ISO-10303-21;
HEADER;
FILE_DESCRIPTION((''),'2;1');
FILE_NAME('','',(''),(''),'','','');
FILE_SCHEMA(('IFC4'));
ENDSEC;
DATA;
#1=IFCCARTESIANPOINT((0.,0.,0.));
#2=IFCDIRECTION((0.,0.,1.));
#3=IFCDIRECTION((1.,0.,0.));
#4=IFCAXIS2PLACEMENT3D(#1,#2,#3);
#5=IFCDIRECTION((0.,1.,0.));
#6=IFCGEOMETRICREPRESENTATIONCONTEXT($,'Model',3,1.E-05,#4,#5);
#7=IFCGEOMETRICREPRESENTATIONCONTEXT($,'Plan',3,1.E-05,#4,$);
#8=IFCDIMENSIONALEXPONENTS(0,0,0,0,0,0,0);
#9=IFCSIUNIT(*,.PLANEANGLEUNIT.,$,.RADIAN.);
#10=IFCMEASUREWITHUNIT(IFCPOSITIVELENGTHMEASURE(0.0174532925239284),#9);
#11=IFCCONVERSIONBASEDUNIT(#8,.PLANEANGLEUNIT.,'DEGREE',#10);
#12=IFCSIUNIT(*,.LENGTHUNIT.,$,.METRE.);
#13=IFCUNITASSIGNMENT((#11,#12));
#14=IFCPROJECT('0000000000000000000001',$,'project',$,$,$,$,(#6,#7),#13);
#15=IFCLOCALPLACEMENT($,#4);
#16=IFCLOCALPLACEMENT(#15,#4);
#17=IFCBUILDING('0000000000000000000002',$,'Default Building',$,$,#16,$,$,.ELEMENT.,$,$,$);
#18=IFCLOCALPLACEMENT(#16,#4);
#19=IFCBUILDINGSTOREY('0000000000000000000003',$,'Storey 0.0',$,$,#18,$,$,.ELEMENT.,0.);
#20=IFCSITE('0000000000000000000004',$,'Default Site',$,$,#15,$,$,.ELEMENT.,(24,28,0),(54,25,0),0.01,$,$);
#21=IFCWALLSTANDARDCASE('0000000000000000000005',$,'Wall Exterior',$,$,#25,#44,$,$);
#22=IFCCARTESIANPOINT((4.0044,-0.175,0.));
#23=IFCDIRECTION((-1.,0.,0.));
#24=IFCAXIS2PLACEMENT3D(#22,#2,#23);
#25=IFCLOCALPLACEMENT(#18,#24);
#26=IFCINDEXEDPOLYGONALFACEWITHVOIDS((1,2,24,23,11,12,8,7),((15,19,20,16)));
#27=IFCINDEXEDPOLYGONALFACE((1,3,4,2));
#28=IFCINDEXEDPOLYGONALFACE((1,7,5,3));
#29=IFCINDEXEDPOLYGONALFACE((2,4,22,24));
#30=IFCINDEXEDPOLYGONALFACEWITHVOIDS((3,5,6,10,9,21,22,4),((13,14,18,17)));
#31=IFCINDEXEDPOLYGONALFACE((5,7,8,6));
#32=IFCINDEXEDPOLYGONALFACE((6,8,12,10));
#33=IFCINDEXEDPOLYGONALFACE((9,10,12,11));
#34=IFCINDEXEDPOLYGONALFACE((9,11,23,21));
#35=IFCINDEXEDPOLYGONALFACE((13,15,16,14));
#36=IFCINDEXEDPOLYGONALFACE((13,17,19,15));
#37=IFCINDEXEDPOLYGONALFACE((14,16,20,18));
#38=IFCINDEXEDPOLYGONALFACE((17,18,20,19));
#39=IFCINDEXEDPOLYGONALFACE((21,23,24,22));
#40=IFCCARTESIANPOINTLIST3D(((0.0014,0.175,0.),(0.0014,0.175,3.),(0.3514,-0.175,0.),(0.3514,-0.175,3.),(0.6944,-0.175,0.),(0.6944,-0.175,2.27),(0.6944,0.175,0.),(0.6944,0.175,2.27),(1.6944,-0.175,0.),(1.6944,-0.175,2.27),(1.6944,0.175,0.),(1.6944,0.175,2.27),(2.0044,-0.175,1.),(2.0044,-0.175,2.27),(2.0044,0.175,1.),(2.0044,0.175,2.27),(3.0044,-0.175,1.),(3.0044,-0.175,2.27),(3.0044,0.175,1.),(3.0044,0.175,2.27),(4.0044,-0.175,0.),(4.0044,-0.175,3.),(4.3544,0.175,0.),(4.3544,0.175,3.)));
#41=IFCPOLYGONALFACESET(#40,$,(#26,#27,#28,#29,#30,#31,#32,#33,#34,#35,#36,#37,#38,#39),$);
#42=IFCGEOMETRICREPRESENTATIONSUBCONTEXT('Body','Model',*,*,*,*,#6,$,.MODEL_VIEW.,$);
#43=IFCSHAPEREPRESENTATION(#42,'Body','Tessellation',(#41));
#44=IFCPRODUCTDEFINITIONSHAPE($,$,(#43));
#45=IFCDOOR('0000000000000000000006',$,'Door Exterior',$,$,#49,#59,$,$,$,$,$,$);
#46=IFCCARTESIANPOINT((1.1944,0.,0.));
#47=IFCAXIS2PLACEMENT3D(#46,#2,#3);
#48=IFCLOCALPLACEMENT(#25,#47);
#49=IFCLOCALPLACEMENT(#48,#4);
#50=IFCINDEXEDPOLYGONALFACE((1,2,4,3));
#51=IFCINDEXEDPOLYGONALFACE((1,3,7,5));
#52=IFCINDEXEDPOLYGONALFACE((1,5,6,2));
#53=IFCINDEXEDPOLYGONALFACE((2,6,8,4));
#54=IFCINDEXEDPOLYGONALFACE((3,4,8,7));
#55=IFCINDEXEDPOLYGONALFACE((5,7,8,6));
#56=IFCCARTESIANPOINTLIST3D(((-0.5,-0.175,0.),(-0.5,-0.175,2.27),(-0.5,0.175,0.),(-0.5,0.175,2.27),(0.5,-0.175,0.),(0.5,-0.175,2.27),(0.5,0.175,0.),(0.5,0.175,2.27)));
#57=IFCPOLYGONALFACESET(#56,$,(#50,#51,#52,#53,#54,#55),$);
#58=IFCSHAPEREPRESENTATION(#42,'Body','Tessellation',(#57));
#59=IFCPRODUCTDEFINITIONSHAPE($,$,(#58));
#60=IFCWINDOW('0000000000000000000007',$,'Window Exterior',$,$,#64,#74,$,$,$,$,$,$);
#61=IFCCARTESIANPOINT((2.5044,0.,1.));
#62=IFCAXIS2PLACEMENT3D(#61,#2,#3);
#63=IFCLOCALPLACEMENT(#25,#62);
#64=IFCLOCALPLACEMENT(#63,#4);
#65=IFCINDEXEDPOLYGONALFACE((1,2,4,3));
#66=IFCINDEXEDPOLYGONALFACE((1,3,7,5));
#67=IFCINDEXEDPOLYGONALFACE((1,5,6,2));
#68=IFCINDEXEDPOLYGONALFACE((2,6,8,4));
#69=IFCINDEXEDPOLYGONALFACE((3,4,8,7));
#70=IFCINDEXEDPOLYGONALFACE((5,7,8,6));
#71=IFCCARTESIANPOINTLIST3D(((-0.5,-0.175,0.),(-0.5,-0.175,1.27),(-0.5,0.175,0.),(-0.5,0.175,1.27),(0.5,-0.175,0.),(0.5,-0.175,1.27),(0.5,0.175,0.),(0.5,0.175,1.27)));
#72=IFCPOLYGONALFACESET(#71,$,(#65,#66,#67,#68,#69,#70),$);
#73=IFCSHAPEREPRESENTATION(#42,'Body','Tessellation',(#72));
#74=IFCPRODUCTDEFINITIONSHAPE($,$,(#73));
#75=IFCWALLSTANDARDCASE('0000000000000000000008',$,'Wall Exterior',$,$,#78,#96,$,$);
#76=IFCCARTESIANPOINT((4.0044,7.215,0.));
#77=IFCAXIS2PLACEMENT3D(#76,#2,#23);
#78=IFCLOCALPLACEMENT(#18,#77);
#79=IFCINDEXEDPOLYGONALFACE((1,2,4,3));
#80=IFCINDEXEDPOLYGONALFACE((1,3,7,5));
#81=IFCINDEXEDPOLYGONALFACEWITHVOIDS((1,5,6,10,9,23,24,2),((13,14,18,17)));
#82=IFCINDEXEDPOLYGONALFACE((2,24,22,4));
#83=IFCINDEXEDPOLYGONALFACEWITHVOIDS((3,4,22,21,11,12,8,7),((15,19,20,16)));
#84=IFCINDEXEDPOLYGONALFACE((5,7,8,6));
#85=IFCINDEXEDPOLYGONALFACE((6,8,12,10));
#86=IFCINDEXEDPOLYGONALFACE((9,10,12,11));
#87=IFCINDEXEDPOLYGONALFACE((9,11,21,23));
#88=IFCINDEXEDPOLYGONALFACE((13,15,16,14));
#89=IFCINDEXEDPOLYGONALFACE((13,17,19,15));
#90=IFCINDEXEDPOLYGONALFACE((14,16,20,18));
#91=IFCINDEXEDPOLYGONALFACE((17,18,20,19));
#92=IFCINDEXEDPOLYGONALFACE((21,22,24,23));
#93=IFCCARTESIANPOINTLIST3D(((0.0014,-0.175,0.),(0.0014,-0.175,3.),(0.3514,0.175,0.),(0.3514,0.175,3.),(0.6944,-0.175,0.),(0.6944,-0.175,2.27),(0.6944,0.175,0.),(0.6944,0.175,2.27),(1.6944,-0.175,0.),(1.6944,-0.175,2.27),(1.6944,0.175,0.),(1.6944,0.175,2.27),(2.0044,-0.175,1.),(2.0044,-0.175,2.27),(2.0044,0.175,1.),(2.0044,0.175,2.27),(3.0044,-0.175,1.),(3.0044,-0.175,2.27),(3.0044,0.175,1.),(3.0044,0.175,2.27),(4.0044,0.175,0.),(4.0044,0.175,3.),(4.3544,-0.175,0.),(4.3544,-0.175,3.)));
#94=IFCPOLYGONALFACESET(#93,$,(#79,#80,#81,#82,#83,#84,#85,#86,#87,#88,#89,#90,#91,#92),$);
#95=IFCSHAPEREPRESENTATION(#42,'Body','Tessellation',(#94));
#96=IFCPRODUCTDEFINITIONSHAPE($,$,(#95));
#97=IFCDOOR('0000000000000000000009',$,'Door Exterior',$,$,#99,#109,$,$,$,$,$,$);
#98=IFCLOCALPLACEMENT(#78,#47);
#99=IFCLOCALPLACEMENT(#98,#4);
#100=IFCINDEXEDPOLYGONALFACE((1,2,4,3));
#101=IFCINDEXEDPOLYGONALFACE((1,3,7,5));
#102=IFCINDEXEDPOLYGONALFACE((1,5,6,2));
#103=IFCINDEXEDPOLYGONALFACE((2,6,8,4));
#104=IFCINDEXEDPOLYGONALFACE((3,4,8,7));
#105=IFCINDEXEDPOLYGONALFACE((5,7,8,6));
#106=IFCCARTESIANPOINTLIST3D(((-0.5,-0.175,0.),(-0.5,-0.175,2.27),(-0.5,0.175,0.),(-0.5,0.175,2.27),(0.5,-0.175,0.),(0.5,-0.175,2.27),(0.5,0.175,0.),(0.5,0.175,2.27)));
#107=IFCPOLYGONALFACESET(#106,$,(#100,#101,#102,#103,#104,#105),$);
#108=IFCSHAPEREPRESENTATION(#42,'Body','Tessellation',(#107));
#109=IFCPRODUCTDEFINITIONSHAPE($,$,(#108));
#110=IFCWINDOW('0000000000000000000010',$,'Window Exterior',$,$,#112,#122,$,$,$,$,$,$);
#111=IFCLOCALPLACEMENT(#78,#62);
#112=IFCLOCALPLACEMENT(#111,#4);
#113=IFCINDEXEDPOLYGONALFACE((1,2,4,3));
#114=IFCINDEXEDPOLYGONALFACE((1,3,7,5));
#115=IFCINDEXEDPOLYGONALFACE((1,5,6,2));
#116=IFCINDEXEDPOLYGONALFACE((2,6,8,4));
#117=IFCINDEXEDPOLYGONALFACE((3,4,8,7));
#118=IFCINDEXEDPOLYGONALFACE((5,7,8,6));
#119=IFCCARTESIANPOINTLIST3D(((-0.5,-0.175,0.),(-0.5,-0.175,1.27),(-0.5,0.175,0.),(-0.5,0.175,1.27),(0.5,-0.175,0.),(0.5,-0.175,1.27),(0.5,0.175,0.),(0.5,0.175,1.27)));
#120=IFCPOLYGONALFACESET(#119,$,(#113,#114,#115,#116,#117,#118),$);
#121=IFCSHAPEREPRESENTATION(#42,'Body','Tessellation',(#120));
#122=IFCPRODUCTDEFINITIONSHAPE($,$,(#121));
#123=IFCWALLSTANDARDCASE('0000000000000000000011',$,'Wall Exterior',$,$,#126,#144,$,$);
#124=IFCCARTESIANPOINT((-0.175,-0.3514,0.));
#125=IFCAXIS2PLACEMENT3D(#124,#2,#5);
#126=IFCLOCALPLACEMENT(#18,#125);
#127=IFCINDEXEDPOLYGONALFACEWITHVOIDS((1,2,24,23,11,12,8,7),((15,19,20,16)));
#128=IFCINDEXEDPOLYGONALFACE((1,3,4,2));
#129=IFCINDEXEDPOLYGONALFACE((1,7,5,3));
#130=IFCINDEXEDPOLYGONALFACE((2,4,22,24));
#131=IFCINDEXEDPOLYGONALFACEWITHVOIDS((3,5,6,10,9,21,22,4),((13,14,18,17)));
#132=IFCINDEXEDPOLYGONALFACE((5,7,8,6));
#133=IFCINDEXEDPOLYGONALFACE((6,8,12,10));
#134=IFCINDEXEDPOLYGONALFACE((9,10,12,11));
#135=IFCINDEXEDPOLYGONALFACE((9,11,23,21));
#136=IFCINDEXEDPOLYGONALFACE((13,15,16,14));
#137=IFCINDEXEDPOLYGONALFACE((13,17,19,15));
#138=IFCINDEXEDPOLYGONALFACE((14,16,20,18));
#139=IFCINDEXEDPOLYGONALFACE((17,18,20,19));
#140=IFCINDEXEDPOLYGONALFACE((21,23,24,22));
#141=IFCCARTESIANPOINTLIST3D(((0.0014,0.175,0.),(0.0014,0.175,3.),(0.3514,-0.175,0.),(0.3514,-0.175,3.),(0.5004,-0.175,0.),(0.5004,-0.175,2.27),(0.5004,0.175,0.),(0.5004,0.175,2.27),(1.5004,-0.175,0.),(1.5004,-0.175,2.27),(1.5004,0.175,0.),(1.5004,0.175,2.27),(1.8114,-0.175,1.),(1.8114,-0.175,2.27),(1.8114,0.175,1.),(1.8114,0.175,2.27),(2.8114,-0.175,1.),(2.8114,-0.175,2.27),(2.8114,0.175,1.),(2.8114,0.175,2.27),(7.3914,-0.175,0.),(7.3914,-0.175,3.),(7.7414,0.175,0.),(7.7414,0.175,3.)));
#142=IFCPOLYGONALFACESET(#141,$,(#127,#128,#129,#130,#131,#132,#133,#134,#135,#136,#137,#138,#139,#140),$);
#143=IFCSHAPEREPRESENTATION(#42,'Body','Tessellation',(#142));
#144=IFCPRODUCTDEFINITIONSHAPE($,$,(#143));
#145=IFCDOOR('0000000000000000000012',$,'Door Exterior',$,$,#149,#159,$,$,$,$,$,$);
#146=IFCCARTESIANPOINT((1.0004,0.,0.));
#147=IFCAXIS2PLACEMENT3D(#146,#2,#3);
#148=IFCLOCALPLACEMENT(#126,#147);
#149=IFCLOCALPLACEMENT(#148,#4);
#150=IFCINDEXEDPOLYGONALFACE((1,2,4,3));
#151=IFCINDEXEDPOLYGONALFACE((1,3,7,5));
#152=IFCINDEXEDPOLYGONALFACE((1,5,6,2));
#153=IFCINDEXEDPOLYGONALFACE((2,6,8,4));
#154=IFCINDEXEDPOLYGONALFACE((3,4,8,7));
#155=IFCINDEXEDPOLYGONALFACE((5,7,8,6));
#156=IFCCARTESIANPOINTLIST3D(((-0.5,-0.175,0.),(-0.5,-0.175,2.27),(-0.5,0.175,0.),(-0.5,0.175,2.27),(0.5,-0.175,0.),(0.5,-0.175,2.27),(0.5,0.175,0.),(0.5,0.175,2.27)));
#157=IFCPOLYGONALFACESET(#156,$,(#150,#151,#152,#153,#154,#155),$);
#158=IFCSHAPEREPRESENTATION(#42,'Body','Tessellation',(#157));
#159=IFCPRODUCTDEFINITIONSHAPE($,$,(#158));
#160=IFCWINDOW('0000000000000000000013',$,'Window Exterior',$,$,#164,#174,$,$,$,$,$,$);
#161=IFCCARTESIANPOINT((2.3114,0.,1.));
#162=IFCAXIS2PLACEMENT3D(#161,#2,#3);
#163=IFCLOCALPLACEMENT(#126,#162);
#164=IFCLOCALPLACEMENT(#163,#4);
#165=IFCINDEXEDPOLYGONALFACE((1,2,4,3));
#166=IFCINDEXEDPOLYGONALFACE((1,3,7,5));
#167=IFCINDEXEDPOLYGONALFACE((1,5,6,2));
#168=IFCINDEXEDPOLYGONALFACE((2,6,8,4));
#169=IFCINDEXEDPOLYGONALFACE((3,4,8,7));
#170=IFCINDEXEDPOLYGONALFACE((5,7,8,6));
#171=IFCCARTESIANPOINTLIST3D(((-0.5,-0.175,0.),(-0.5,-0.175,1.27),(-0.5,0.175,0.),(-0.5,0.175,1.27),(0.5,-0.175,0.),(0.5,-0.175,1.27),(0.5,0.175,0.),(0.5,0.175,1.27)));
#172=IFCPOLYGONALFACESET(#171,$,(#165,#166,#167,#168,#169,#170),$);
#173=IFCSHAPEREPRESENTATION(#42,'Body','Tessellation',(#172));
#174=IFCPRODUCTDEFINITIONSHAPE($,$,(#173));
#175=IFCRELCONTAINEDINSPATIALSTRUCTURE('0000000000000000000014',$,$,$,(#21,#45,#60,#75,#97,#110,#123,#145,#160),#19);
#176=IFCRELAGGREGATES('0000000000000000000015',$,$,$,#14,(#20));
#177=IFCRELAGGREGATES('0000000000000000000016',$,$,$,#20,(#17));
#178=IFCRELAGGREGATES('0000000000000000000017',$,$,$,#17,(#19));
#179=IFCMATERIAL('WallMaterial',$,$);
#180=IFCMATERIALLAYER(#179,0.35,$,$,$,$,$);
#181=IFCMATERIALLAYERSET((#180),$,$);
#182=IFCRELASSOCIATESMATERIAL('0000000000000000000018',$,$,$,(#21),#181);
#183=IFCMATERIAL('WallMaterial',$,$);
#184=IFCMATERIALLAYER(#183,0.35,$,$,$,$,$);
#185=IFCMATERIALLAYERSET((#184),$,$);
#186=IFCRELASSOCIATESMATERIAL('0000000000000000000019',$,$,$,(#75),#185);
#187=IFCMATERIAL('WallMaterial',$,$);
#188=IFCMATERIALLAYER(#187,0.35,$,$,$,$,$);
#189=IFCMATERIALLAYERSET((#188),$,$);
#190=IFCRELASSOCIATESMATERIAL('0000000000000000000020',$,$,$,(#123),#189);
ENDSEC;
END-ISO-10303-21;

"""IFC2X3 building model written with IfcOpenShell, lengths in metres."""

from ifc_helpers import new_model, entity, si_unit, converted_unit, direction, frame, origin_with_axes, place, context, subcontext, project, spatial, polyline, outline, extrude, material, layer, layer_set, layer_usage, element, fill, save


model = new_model("IFC2X3")

# Units and contexts
model_context = context("Model", 3, precision=1e-05, world=origin_with_axes(), true_north=direction((0.0, 1.0, 0.0)))
plan_context = context("Plan", 3, precision=1e-05, world=origin_with_axes())
body_context = subcontext(model_context, "Body", "Model", "MODEL_VIEW")
ifc_project = project(units=[converted_unit("PLANEANGLEUNIT", "DEGREE", entity("IfcPositiveLengthMeasure", 0.0174532925239284), si_unit("PLANEANGLEUNIT", "RADIAN"), dimensions=[0, 0, 0, 0, 0, 0, 0]), si_unit("LENGTHUNIT", "METRE")], contexts=[model_context, plan_context])

# Site, building, storey
site_placement = place(None, origin_with_axes())
site = spatial("IfcSite", under=ifc_project, at=site_placement, Name="Default Site", CompositionType="ELEMENT", RefLatitude=(24, 28, 0), RefLongitude=(54, 25, 0), RefElevation=0.01)
building_placement = place(site_placement, origin_with_axes())
building = spatial("IfcBuilding", under=site, at=building_placement, Name="Default Building", CompositionType="ELEMENT")
storey_placement = place(building_placement, origin_with_axes())
storey = spatial("IfcBuildingStorey", under=building, at=storey_placement, Name="Storey 0.0", CompositionType="ELEMENT", Elevation=0.0)

# Walls, openings, doors, windows
ifc_material_1 = material(Name="WallMaterial")
ifc_layer_1 = layer(ifc_material_1, 0.35)
ifc_layer_set_1 = layer_set([ifc_layer_1])
ifc_layer_usage_1 = layer_usage(ifc_layer_set_1, "AXIS2", "POSITIVE", -0.175)
wall_1_placement = place(storey_placement, frame((4.0044, -0.175, 0.0), z_axis=(0.0, 0.0, 1.0), x_axis=(-1.0, 0.0, 0.0)))
wall_1 = element("IfcWallStandardCase", 1, at=wall_1_placement, inside=storey, material=ifc_layer_usage_1, Name="Wall Exterior", context=body_context, shape_type="SweptSolid", body=[
    extrude(outline(polyline([(0.3514, -0.175), (4.0044, -0.175), (4.3544, 0.175), (0.0014, 0.175), (0.3514, -0.175)])), origin_with_axes(), (0.0, 0.0, 1.0), 3.0),
])
opening_1_placement = place(wall_1_placement, frame((1.1944, 0.0, 0.0), z_axis=(0.0, 0.0, 1.0), x_axis=(1.0, 0.0, 0.0)))
opening_1 = element("IfcOpeningElement", 2, at=opening_1_placement, cuts=wall_1, context=body_context, shape_type="SweptSolid", body=[
    extrude(outline(polyline([(-0.5, 0.372), (0.5, 0.372), (0.5, -0.372), (-0.5, -0.372), (-0.5, 0.372)])), origin_with_axes(), (0.0, 0.0, 1.0), 2.27),
])
opening_2_placement = place(wall_1_placement, frame((2.5044, 0.0, 1.0), z_axis=(0.0, 0.0, 1.0), x_axis=(1.0, 0.0, 0.0)))
opening_2 = element("IfcOpeningElement", 3, at=opening_2_placement, cuts=wall_1, context=body_context, shape_type="SweptSolid", body=[
    extrude(outline(polyline([(-0.5, 0.372), (0.5, 0.372), (0.5, -0.372), (-0.5, -0.372), (-0.5, 0.372)])), origin_with_axes(), (0.0, 0.0, 1.0), 1.27),
])
door_1_placement = place(opening_1_placement, origin_with_axes())
door_1 = element("IfcDoor", 4, at=door_1_placement, inside=storey, Name="Door Exterior", context=body_context, shape_type="SweptSolid", body=[
    extrude(outline(polyline([(-0.5, 0.175), (0.5, 0.175), (0.5, -0.175), (-0.5, -0.175), (-0.5, 0.175)])), origin_with_axes(), (0.0, 0.0, 1.0), 2.27),
])
fill(opening_1, door_1)
window_1_placement = place(opening_2_placement, origin_with_axes())
window_1 = element("IfcWindow", 5, at=window_1_placement, inside=storey, Name="Window Exterior", context=body_context, shape_type="SweptSolid", body=[
    extrude(outline(polyline([(-0.5, 0.175), (0.5, 0.175), (0.5, -0.175), (-0.5, -0.175), (-0.5, 0.175)])), origin_with_axes(), (0.0, 0.0, 1.0), 1.27),
])
fill(opening_2, window_1)
ifc_material_2 = material(Name="WallMaterial")
ifc_layer_2 = layer(ifc_material_2, 0.35)
ifc_layer_set_2 = layer_set([ifc_layer_2])
ifc_layer_usage_2 = layer_usage(ifc_layer_set_2, "AXIS2", "POSITIVE", -0.175)
wall_2_placement = place(storey_placement, frame((4.0044, 7.215, 0.0), z_axis=(0.0, 0.0, 1.0), x_axis=(-1.0, 0.0, 0.0)))
wall_2 = element("IfcWallStandardCase", 6, at=wall_2_placement, inside=storey, material=ifc_layer_usage_2, Name="Wall Exterior", context=body_context, shape_type="SweptSolid", body=[
    extrude(outline(polyline([(0.0014, -0.175), (4.3544, -0.175), (4.0044, 0.175), (0.3514, 0.175), (0.0014, -0.175)])), origin_with_axes(), (0.0, 0.0, 1.0), 3.0),
])
opening_3_placement = place(wall_2_placement, frame((1.1944, 0.0, 0.0), z_axis=(0.0, 0.0, 1.0), x_axis=(1.0, 0.0, 0.0)))
opening_3 = element("IfcOpeningElement", 7, at=opening_3_placement, cuts=wall_2, context=body_context, shape_type="SweptSolid", body=[
    extrude(outline(polyline([(-0.5, 0.372), (0.5, 0.372), (0.5, -0.372), (-0.5, -0.372), (-0.5, 0.372)])), origin_with_axes(), (0.0, 0.0, 1.0), 2.27),
])
opening_4_placement = place(wall_2_placement, frame((2.5044, 0.0, 1.0), z_axis=(0.0, 0.0, 1.0), x_axis=(1.0, 0.0, 0.0)))
opening_4 = element("IfcOpeningElement", 8, at=opening_4_placement, cuts=wall_2, context=body_context, shape_type="SweptSolid", body=[
    extrude(outline(polyline([(-0.5, 0.372), (0.5, 0.372), (0.5, -0.372), (-0.5, -0.372), (-0.5, 0.372)])), origin_with_axes(), (0.0, 0.0, 1.0), 1.27),
])
door_2_placement = place(opening_3_placement, origin_with_axes())
door_2 = element("IfcDoor", 9, at=door_2_placement, inside=storey, Name="Door Exterior", context=body_context, shape_type="SweptSolid", body=[
    extrude(outline(polyline([(-0.5, 0.175), (0.5, 0.175), (0.5, -0.175), (-0.5, -0.175), (-0.5, 0.175)])), origin_with_axes(), (0.0, 0.0, 1.0), 2.27),
])
fill(opening_3, door_2)
window_2_placement = place(opening_4_placement, origin_with_axes())
window_2 = element("IfcWindow", 10, at=window_2_placement, inside=storey, Name="Window Exterior", context=body_context, shape_type="SweptSolid", body=[
    extrude(outline(polyline([(-0.5, 0.175), (0.5, 0.175), (0.5, -0.175), (-0.5, -0.175), (-0.5, 0.175)])), origin_with_axes(), (0.0, 0.0, 1.0), 1.27),
])
fill(opening_4, window_2)
ifc_material_3 = material(Name="WallMaterial")
ifc_layer_3 = layer(ifc_material_3, 0.35)
ifc_layer_set_3 = layer_set([ifc_layer_3])
ifc_layer_usage_3 = layer_usage(ifc_layer_set_3, "AXIS2", "POSITIVE", -0.175)
wall_3_placement = place(storey_placement, frame((-0.175, -0.3514, 0.0), z_axis=(0.0, 0.0, 1.0), x_axis=(0.0, 1.0, 0.0)))
wall_3 = element("IfcWallStandardCase", 11, at=wall_3_placement, inside=storey, material=ifc_layer_usage_3, Name="Wall Exterior", context=body_context, shape_type="SweptSolid", body=[
    extrude(outline(polyline([(0.3514, -0.175), (7.3914, -0.175), (7.7414, 0.175), (0.0014, 0.175), (0.3514, -0.175)])), origin_with_axes(), (0.0, 0.0, 1.0), 3.0),
])
opening_5_placement = place(wall_3_placement, frame((1.0004, 0.0, 0.0), z_axis=(0.0, 0.0, 1.0), x_axis=(1.0, 0.0, 0.0)))
opening_5 = element("IfcOpeningElement", 12, at=opening_5_placement, cuts=wall_3, context=body_context, shape_type="SweptSolid", body=[
    extrude(outline(polyline([(-0.5, 0.372), (0.5, 0.372), (0.5, -0.372), (-0.5, -0.372), (-0.5, 0.372)])), origin_with_axes(), (0.0, 0.0, 1.0), 2.27),
])
opening_6_placement = place(wall_3_placement, frame((2.3114, 0.0, 1.0), z_axis=(0.0, 0.0, 1.0), x_axis=(1.0, 0.0, 0.0)))
opening_6 = element("IfcOpeningElement", 13, at=opening_6_placement, cuts=wall_3, context=body_context, shape_type="SweptSolid", body=[
    extrude(outline(polyline([(-0.5, 0.372), (0.5, 0.372), (0.5, -0.372), (-0.5, -0.372), (-0.5, 0.372)])), origin_with_axes(), (0.0, 0.0, 1.0), 1.27),
])
door_3_placement = place(opening_5_placement, origin_with_axes())
door_3 = element("IfcDoor", 14, at=door_3_placement, inside=storey, Name="Door Exterior", context=body_context, shape_type="SweptSolid", body=[
    extrude(outline(polyline([(-0.5, 0.175), (0.5, 0.175), (0.5, -0.175), (-0.5, -0.175), (-0.5, 0.175)])), origin_with_axes(), (0.0, 0.0, 1.0), 2.27),
])
fill(opening_5, door_3)
window_3_placement = place(opening_6_placement, origin_with_axes())
window_3 = element("IfcWindow", 15, at=window_3_placement, inside=storey, Name="Window Exterior", context=body_context, shape_type="SweptSolid", body=[
    extrude(outline(polyline([(-0.5, 0.175), (0.5, 0.175), (0.5, -0.175), (-0.5, -0.175), (-0.5, 0.175)])), origin_with_axes(), (0.0, 0.0, 1.0), 1.27),
])
fill(opening_6, window_3)

save(model, "model.ifc")
